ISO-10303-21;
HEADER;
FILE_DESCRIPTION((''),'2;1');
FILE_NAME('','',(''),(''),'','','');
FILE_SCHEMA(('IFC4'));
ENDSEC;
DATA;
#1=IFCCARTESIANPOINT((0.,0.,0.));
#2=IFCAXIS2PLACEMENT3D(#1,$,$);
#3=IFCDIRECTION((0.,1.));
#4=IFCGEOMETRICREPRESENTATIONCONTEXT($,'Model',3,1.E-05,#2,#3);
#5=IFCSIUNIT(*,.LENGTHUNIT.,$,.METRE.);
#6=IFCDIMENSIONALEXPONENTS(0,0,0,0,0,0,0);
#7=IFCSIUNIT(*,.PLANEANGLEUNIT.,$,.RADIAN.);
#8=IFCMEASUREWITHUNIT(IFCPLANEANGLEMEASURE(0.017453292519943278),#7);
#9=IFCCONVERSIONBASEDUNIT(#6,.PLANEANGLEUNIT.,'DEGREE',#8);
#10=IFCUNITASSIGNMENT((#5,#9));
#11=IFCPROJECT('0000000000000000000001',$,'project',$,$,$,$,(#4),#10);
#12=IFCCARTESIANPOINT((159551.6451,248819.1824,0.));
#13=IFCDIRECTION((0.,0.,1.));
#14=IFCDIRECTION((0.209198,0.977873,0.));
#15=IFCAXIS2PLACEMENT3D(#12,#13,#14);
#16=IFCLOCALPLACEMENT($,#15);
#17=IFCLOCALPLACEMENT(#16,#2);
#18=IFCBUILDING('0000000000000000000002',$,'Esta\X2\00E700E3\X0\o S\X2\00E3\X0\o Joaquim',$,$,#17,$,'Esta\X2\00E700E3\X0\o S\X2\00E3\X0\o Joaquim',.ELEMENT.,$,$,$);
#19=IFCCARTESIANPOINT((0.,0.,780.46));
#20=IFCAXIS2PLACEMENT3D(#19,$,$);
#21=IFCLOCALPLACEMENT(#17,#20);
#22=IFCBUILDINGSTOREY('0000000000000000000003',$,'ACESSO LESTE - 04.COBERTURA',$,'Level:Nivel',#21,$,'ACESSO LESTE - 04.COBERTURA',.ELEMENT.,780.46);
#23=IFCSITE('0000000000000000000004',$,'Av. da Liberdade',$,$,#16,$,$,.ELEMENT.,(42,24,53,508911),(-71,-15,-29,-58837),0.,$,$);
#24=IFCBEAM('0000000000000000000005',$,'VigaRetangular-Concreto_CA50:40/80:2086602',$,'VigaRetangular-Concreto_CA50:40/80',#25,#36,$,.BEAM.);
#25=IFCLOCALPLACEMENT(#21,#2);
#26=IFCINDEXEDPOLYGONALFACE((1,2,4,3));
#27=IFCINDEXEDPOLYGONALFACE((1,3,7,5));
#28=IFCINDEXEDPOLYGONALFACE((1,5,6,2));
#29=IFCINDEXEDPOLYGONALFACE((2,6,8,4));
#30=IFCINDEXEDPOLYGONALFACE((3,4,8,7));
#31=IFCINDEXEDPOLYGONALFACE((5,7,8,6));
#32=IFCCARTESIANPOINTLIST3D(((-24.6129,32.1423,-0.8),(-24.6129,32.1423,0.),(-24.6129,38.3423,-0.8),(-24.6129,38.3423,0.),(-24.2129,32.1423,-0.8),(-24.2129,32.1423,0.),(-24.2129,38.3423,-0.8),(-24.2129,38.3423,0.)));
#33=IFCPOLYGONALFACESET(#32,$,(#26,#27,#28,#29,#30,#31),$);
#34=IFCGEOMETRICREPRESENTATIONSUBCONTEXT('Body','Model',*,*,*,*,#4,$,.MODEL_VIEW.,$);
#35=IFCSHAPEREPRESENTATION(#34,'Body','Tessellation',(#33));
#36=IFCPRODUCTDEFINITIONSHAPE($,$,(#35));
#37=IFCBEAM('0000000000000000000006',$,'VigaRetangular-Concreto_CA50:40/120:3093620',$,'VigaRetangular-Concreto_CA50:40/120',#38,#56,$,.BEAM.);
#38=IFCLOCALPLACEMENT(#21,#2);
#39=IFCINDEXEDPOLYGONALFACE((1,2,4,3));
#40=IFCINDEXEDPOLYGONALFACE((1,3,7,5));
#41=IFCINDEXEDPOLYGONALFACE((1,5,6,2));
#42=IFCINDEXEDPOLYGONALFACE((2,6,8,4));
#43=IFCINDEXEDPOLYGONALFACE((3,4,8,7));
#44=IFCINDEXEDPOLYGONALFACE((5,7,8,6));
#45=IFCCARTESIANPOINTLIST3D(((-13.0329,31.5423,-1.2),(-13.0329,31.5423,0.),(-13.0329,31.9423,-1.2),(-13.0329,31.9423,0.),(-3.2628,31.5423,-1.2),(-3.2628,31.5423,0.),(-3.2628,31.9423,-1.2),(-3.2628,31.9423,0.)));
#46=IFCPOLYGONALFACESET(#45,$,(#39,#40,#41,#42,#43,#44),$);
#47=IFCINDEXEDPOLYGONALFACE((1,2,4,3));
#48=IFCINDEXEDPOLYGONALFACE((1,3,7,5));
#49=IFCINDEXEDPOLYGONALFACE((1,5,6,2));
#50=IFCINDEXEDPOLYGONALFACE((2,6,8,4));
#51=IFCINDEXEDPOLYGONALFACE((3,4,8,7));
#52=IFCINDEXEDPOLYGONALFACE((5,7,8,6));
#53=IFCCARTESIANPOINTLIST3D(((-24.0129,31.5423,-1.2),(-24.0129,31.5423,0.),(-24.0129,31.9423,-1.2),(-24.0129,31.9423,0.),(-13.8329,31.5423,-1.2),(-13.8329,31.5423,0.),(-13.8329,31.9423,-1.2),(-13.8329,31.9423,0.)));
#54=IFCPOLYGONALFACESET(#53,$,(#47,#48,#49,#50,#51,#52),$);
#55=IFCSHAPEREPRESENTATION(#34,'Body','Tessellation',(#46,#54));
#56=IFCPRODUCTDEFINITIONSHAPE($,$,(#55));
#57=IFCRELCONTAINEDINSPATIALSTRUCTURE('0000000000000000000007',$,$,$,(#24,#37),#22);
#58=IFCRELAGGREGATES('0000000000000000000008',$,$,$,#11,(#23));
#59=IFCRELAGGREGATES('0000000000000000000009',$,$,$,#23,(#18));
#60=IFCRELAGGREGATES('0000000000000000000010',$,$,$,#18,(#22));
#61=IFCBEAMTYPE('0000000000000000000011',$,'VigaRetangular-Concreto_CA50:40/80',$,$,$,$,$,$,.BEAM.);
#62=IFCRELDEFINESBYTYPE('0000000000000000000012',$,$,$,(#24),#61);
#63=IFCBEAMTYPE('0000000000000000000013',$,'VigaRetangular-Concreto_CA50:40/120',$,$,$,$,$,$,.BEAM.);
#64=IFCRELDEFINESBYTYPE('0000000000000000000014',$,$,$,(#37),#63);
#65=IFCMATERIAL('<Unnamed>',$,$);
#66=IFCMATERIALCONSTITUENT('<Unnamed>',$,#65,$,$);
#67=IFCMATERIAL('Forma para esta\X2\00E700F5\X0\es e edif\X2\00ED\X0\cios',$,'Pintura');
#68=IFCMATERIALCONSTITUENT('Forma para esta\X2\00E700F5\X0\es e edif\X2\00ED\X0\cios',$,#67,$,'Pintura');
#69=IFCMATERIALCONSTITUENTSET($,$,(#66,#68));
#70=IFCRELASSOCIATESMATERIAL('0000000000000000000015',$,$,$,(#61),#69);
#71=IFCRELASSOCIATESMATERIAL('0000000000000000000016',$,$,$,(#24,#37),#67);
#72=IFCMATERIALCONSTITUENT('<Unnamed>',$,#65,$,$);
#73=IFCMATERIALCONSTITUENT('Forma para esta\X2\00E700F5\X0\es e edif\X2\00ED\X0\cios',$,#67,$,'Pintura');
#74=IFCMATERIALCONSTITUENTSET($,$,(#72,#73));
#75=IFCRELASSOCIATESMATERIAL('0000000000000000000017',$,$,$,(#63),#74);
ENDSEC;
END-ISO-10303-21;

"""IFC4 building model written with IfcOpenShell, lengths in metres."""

from ifc_helpers import new_model, entity, si_unit, converted_unit, direction, frame, origin, place, context, subcontext, project, spatial, indexed_curve, outline, extrude, source, transform, mapped, material, constituent, constituent_set, type_object, type_shapes, element, save


model = new_model("IFC4")

# Units and contexts
model_context = context("Model", 3, precision=1e-05, world=origin(), true_north=direction((0.0, 1.0)))
body_context = subcontext(model_context, "Body", "Model", "MODEL_VIEW")
ifc_project = project(units=[si_unit("LENGTHUNIT", "METRE"), converted_unit("PLANEANGLEUNIT", "DEGREE", entity("IfcPlaneAngleMeasure", 0.017453292519943278), si_unit("PLANEANGLEUNIT", "RADIAN"), dimensions=[0, 0, 0, 0, 0, 0, 0])], contexts=[model_context])

# Site, building, storey
site_placement = place(None, frame((159551.6451, 248819.1824, 0.0), z_axis=(0.0, 0.0, 1.0), x_axis=(0.209198, 0.977873, 0.0)))
site = spatial("IfcSite", under=ifc_project, at=site_placement, Name="Av. da Liberdade", CompositionType="ELEMENT", RefLatitude=(42, 24, 53, 508911), RefLongitude=(-71, -15, -29, -58837), RefElevation=0.0)
building_placement = place(site_placement, origin())
building = spatial("IfcBuilding", under=site, at=building_placement, Name="Estação São Joaquim", LongName="Estação São Joaquim", CompositionType="ELEMENT")
storey_placement = place(building_placement, frame((0.0, 0.0, 780.46)))
storey = spatial("IfcBuildingStorey", under=building, at=storey_placement, Name="ACESSO LESTE - 04.COBERTURA", ObjectType="Level:Nivel", LongName="ACESSO LESTE - 04.COBERTURA", CompositionType="ELEMENT", Elevation=780.46)

# Beams
ifc_material_1 = material(Name="Forma para estações e edifícios", Category="Pintura")
ifc_material_2 = material(Name="<Unnamed>")
ifc_constituent_1 = constituent(ifc_material_2, Name="<Unnamed>")
ifc_constituent_2 = constituent(ifc_material_1, Name="Forma para estações e edifícios", Category="Pintura")
ifc_constituent_set_1 = constituent_set(constituents=[ifc_constituent_1, ifc_constituent_2])
beam_type_1 = type_object("IfcBeamType", Name="VigaRetangular-Concreto_CA50:40/80", PredefinedType="BEAM", material=ifc_constituent_set_1)
shared_shape_1 = source(origin(), body_context, "Body", "SweptSolid", [
    extrude(outline(indexed_curve([(-0.2, -0.4), (0.2, -0.4), (0.2, 0.4), (-0.2, 0.4), (-0.2, -0.4)], self_intersect=False)), frame((-24.4129, 32.1423, 780.06), z_axis=(0.0, 1.0, 0.0), x_axis=(-1.0, 0.0, 0.0)), (0.0, 0.0, 1.0), 6.2),
])
type_shapes(beam_type_1, [shared_shape_1])
beam_1_placement = place(storey_placement, frame((0.0, 0.0, -780.46)))
element("IfcBeam", 1, at=beam_1_placement, inside=storey, type_object=beam_type_1, material=ifc_material_1, Name="VigaRetangular-Concreto_CA50:40/80:2086602", ObjectType="VigaRetangular-Concreto_CA50:40/80", PredefinedType="BEAM", context=body_context, shape_type="MappedRepresentation", body=[
    mapped(shared_shape_1, transform((0.0, 0.0, 0.0), scale=1.0)),
])
ifc_constituent_3 = constituent(ifc_material_2, Name="<Unnamed>")
ifc_constituent_4 = constituent(ifc_material_1, Name="Forma para estações e edifícios", Category="Pintura")
ifc_constituent_set_2 = constituent_set(constituents=[ifc_constituent_3, ifc_constituent_4])
beam_type_2 = type_object("IfcBeamType", Name="VigaRetangular-Concreto_CA50:40/120", PredefinedType="BEAM", material=ifc_constituent_set_2)
shared_shape_2 = source(origin(), body_context, "Body", "SweptSolid", [
    extrude(outline(indexed_curve([(-0.6, -0.2), (0.6, -0.2), (0.6, 0.2), (-0.6, 0.2), (-0.6, -0.2)], self_intersect=False)), frame((-13.0329, 31.7423, 779.86), z_axis=(1.0, 0.0, 0.0), x_axis=(0.0, 0.0, -1.0)), (0.0, 0.0, 1.0), 9.7701),
    extrude(outline(indexed_curve([(-0.6, -0.2), (0.6, -0.2), (0.6, 0.2), (-0.6, 0.2), (-0.6, -0.2)], self_intersect=False)), frame((-24.0129, 31.7423, 779.86), z_axis=(1.0, 0.0, 0.0), x_axis=(0.0, 0.0, -1.0)), (0.0, 0.0, 1.0), 10.18),
])
type_shapes(beam_type_2, [shared_shape_2])
beam_2_placement = place(storey_placement, frame((0.0, 0.0, -780.46)))
element("IfcBeam", 2, at=beam_2_placement, inside=storey, type_object=beam_type_2, material=ifc_material_1, Name="VigaRetangular-Concreto_CA50:40/120:3093620", ObjectType="VigaRetangular-Concreto_CA50:40/120", PredefinedType="BEAM", context=body_context, shape_type="MappedRepresentation", body=[
    mapped(shared_shape_2, transform((0.0, 0.0, 0.0), scale=1.0)),
])

save(model, "model.ifc")
